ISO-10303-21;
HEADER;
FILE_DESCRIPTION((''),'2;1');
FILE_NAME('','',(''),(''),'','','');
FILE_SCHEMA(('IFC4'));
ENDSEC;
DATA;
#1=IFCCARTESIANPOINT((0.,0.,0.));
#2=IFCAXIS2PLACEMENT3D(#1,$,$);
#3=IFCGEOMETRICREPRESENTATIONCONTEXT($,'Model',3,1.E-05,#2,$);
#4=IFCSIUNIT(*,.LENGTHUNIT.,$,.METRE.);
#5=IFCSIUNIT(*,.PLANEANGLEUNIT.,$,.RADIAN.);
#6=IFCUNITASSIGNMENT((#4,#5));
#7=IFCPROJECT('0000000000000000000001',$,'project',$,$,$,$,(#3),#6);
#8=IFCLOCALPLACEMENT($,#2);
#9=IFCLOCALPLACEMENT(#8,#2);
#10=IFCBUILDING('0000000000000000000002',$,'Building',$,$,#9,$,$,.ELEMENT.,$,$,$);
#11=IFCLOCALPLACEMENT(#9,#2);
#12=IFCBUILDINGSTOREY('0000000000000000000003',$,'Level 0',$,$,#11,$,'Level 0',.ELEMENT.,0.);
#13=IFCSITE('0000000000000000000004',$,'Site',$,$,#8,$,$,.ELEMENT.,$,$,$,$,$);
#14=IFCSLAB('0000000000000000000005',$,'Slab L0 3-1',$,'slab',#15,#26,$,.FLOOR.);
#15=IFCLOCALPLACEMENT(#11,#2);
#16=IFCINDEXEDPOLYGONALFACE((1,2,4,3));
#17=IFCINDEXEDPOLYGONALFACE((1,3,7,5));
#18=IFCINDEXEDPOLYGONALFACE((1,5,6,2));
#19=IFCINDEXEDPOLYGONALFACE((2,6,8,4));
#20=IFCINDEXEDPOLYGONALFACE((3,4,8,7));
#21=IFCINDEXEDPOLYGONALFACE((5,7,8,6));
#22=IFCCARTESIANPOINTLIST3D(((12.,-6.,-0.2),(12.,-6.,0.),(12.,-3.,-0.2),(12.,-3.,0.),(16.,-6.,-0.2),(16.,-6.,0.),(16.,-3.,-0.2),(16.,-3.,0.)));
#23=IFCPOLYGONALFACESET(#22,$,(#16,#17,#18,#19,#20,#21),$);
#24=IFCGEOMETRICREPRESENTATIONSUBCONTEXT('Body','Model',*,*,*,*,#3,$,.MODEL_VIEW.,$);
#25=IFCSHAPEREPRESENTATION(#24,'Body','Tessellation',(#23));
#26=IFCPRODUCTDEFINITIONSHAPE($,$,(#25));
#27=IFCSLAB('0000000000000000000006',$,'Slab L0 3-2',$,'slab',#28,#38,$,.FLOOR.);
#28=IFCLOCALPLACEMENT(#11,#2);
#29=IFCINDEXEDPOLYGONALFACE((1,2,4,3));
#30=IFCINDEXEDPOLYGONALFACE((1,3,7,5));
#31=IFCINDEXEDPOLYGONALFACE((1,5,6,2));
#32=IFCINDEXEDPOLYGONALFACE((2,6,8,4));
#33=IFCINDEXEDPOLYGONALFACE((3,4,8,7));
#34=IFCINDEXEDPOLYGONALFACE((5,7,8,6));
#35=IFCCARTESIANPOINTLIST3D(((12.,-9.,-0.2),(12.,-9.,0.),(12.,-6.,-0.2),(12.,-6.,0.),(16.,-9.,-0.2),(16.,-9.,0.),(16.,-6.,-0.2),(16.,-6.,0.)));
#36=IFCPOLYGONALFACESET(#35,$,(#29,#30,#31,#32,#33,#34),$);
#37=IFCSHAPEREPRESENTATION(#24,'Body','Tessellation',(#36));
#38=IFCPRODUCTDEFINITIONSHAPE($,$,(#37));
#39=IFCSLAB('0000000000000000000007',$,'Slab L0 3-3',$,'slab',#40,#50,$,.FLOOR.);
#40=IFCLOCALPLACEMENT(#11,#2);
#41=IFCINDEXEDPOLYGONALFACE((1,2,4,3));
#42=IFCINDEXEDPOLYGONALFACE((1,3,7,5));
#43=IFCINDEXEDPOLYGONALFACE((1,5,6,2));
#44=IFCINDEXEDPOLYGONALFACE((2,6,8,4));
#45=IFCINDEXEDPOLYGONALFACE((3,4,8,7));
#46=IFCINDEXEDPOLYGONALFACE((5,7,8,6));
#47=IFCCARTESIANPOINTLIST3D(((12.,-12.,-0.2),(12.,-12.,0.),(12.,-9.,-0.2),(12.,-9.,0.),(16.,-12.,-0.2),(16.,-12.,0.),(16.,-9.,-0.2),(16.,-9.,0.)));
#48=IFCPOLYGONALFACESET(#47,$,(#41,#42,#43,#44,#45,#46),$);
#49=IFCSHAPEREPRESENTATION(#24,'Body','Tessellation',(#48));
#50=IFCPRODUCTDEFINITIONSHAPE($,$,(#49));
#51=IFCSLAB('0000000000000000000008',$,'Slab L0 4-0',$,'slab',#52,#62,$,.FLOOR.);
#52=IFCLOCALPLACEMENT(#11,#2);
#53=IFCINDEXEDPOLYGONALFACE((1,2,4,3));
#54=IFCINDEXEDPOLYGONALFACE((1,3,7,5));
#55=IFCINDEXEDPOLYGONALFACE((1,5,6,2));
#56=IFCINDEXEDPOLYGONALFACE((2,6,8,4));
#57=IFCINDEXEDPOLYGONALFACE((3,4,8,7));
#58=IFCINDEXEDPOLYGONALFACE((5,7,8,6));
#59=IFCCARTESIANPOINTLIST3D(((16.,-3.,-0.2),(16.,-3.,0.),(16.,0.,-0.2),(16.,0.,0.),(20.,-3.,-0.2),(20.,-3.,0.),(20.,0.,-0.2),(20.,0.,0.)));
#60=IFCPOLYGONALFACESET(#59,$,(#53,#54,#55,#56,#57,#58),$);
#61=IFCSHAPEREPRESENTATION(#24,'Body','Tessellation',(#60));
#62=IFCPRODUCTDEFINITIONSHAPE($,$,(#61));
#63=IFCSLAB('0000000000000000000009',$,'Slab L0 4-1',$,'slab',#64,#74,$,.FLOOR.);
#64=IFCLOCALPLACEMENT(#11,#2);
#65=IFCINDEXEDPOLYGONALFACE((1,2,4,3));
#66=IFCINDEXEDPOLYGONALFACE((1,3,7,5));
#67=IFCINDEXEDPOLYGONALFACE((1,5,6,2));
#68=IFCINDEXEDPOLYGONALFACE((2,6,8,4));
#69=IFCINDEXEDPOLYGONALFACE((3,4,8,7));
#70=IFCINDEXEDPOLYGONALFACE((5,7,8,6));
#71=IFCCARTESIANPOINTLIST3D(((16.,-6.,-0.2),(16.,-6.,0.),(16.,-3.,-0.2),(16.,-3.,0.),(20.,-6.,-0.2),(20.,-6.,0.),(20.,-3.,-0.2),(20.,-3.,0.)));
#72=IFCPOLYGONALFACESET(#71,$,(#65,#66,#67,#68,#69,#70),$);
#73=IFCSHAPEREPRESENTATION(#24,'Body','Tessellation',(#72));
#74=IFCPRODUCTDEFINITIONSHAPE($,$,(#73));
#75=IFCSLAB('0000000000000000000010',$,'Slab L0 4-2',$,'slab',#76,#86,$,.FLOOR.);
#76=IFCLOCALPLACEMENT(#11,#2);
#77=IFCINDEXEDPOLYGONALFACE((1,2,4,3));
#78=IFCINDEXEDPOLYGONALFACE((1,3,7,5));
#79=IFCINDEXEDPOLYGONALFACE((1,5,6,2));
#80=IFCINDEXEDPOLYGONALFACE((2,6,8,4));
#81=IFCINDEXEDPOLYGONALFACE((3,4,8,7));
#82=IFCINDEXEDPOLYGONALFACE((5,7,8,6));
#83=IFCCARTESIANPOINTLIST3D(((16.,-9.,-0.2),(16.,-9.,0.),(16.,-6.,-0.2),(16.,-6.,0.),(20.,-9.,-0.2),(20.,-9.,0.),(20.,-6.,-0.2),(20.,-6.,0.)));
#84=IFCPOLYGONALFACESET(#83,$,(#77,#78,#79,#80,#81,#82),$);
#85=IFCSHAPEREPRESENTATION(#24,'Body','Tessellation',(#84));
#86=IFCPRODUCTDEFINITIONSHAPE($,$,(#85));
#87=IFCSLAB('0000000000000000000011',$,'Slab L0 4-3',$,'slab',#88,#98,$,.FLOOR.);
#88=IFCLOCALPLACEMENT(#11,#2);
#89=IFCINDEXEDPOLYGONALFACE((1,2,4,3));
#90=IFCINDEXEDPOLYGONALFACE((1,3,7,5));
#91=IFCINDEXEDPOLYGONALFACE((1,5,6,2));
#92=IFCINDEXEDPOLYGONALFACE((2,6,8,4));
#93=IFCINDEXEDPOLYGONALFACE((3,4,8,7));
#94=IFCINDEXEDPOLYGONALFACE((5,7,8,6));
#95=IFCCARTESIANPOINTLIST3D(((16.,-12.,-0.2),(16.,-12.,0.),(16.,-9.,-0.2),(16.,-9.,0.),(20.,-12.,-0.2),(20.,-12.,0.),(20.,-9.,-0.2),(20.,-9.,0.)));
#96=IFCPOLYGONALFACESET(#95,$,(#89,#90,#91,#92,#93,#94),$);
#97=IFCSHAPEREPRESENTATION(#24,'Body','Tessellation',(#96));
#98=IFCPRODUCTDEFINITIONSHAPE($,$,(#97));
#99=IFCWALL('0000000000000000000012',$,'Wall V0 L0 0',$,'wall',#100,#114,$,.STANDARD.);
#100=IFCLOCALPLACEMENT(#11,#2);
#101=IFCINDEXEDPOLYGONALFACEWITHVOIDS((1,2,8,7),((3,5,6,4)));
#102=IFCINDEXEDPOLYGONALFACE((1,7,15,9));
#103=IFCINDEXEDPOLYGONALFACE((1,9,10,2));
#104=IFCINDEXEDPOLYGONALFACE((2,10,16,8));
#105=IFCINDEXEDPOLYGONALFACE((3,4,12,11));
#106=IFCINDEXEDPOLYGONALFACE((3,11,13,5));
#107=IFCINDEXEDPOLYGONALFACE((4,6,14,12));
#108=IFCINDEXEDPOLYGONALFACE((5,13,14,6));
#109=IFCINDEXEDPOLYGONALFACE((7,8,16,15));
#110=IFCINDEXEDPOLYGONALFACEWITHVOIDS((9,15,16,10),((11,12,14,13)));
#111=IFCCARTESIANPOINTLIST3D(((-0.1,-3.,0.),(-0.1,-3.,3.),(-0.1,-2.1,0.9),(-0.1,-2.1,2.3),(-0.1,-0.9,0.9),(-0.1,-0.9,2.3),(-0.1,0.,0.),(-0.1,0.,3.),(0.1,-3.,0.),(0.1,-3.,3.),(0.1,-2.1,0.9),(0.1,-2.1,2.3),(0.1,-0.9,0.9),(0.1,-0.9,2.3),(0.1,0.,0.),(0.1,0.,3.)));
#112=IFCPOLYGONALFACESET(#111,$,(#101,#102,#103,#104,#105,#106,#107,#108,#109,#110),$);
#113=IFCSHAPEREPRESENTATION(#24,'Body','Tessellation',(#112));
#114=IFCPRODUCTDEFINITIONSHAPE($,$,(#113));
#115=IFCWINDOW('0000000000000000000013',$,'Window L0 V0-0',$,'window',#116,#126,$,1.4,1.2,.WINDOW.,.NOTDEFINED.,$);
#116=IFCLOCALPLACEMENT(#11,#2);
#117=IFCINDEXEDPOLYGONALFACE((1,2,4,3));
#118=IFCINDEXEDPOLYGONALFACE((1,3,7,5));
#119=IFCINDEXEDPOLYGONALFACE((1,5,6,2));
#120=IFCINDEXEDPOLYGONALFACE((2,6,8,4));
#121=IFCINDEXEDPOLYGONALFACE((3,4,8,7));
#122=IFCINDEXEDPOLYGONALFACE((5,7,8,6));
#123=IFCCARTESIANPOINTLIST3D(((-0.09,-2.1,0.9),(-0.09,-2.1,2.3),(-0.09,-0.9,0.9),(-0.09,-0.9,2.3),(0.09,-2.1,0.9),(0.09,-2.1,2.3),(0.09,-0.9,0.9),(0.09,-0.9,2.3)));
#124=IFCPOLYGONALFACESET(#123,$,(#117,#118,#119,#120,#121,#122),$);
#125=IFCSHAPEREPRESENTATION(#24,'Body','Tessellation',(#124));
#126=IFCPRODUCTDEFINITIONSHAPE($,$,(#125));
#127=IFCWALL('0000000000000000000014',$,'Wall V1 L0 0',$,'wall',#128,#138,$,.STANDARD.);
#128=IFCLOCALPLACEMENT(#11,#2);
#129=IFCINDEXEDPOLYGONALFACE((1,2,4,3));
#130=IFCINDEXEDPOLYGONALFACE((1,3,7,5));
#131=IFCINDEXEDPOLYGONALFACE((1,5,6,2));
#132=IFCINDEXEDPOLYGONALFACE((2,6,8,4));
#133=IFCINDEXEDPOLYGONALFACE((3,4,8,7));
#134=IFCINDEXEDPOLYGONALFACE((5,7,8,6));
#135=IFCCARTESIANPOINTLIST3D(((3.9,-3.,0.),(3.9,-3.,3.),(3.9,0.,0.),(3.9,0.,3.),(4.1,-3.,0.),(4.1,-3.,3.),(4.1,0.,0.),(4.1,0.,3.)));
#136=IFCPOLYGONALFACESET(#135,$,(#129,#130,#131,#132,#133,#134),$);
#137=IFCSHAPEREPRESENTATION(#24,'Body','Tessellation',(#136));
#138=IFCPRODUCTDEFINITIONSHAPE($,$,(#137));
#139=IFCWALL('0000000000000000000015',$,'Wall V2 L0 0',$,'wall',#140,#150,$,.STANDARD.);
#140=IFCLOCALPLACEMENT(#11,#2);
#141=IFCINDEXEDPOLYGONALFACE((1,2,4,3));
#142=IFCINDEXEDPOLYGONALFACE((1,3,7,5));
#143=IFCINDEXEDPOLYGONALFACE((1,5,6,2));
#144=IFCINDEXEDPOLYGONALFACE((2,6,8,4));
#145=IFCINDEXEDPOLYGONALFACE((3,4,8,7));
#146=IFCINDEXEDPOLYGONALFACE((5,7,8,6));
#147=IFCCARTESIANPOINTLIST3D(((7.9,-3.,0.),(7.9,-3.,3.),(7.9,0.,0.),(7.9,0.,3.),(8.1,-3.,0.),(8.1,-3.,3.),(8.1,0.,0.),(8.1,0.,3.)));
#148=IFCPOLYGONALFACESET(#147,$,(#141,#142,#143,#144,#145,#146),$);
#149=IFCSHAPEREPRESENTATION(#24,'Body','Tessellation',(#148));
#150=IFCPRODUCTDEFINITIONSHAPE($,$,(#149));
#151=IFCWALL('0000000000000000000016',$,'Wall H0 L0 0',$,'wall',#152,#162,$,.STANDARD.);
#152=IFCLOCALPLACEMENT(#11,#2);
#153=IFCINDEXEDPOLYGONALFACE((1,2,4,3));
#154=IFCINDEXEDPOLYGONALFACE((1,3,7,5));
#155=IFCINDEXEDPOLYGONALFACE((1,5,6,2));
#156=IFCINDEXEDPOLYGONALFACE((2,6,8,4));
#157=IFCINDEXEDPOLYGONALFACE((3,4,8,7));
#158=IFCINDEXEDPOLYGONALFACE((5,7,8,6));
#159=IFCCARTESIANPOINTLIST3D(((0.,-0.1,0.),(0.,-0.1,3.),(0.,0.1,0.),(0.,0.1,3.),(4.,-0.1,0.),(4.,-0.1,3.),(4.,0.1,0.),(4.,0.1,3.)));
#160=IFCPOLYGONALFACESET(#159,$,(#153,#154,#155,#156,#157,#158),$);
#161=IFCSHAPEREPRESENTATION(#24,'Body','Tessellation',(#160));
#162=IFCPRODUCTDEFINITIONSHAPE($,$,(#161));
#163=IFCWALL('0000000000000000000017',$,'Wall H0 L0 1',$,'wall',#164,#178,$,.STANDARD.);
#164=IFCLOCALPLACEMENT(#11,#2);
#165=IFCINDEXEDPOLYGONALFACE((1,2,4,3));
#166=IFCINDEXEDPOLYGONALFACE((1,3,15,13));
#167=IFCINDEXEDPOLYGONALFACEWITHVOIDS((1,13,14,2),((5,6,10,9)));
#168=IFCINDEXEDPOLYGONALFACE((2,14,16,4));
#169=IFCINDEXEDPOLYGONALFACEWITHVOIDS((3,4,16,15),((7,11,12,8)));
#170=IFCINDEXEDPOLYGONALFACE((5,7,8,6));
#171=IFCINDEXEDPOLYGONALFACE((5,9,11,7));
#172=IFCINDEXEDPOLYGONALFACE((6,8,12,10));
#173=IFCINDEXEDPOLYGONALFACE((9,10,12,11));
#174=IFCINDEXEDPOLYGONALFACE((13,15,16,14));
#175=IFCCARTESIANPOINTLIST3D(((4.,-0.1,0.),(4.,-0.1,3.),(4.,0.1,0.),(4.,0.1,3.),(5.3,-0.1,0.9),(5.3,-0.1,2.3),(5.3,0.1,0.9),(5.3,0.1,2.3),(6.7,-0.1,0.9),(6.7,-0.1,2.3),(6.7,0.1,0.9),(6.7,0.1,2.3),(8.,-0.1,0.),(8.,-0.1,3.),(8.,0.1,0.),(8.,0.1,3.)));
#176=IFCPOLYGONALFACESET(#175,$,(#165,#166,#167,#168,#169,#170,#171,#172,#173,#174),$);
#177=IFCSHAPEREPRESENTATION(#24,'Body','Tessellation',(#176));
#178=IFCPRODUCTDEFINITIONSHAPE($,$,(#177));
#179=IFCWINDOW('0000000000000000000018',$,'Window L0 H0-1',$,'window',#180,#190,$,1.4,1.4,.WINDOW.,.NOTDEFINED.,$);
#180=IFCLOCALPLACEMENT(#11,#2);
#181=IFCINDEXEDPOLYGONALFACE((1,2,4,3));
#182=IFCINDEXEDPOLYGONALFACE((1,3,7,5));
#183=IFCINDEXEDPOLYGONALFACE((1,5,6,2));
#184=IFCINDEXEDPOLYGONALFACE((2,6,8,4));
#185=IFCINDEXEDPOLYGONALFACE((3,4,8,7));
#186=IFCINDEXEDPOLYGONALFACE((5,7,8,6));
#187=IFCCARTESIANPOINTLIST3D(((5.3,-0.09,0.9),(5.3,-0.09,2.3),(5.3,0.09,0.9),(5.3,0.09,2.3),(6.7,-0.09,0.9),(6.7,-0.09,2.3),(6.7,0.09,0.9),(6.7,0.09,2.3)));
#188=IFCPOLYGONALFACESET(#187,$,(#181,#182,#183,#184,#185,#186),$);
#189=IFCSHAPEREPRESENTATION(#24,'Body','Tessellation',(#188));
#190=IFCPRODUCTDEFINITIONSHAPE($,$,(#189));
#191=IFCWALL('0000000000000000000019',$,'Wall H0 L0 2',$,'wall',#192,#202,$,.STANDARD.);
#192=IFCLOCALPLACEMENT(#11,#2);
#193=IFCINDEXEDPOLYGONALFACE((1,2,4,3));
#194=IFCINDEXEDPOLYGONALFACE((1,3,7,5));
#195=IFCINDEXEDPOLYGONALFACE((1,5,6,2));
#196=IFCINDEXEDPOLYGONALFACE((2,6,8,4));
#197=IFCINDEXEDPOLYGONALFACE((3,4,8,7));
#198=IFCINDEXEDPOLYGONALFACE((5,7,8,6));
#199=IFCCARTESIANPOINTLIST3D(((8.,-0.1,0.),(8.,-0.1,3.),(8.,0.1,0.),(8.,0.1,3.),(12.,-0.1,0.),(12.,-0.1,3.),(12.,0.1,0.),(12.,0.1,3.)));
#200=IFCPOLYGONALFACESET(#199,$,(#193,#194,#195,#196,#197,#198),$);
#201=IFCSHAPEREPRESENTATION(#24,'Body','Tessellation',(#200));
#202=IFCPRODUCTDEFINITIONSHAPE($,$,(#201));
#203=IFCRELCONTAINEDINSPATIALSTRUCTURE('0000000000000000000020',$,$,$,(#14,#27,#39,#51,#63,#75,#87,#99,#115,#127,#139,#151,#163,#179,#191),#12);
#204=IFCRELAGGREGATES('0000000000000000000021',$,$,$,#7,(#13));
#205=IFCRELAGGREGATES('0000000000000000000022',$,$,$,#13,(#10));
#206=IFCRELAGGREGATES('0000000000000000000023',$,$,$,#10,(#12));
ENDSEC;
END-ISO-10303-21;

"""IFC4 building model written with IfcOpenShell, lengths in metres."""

from ifc_helpers import new_model, si_unit, frame, frame_2d, origin, origin_with_axes, origin_2d, place, context, subcontext, project, spatial, polyline, rectangle, outline, extrude, element, fill, save


model = new_model("IFC4")

# Units and contexts
model_context = context("Model", 3, precision=1e-05, world=origin())
body_context = subcontext(model_context, "Body", "Model", "MODEL_VIEW")
ifc_project = project(units=[si_unit("LENGTHUNIT", "METRE"), si_unit("PLANEANGLEUNIT", "RADIAN")], contexts=[model_context])

# Site, building, storey
site_placement = place(None, origin())
site = spatial("IfcSite", under=ifc_project, at=site_placement, Name="Site", CompositionType="ELEMENT")
building_placement = place(site_placement, origin())
building = spatial("IfcBuilding", under=site, at=building_placement, Name="Building", CompositionType="ELEMENT")
storey_placement = place(building_placement, origin())
storey = spatial("IfcBuildingStorey", under=building, at=storey_placement, Name="Level 0", LongName="Level 0", CompositionType="ELEMENT", Elevation=0.0)

# Slabs
slab_1_placement = place(storey_placement, frame((0.0, 0.0, -0.2)))
element("IfcSlab", 1, at=slab_1_placement, inside=storey, Name="Slab L0 3-1", ObjectType="slab", PredefinedType="FLOOR", context=body_context, shape_type="SweptSolid", body=[
    extrude(outline(polyline([(12.0, -6.0), (16.0, -6.0), (16.0, -3.0), (12.0, -3.0), (12.0, -6.0)])), origin(), (0.0, 0.0, 1.0), 0.2),
])
slab_2_placement = place(storey_placement, frame((0.0, 0.0, -0.2)))
element("IfcSlab", 2, at=slab_2_placement, inside=storey, Name="Slab L0 3-2", ObjectType="slab", PredefinedType="FLOOR", context=body_context, shape_type="SweptSolid", body=[
    extrude(outline(polyline([(12.0, -9.0), (16.0, -9.0), (16.0, -6.0), (12.0, -6.0), (12.0, -9.0)])), origin(), (0.0, 0.0, 1.0), 0.2),
])
slab_3_placement = place(storey_placement, frame((0.0, 0.0, -0.2)))
element("IfcSlab", 3, at=slab_3_placement, inside=storey, Name="Slab L0 3-3", ObjectType="slab", PredefinedType="FLOOR", context=body_context, shape_type="SweptSolid", body=[
    extrude(outline(polyline([(12.0, -12.0), (16.0, -12.0), (16.0, -9.0), (12.0, -9.0), (12.0, -12.0)])), origin(), (0.0, 0.0, 1.0), 0.2),
])
slab_4_placement = place(storey_placement, frame((0.0, 0.0, -0.2)))
element("IfcSlab", 4, at=slab_4_placement, inside=storey, Name="Slab L0 4-0", ObjectType="slab", PredefinedType="FLOOR", context=body_context, shape_type="SweptSolid", body=[
    extrude(outline(polyline([(16.0, -3.0), (20.0, -3.0), (20.0, 0.0), (16.0, 0.0), (16.0, -3.0)])), origin(), (0.0, 0.0, 1.0), 0.2),
])
slab_5_placement = place(storey_placement, frame((0.0, 0.0, -0.2)))
element("IfcSlab", 5, at=slab_5_placement, inside=storey, Name="Slab L0 4-1", ObjectType="slab", PredefinedType="FLOOR", context=body_context, shape_type="SweptSolid", body=[
    extrude(outline(polyline([(16.0, -6.0), (20.0, -6.0), (20.0, -3.0), (16.0, -3.0), (16.0, -6.0)])), origin(), (0.0, 0.0, 1.0), 0.2),
])
slab_6_placement = place(storey_placement, frame((0.0, 0.0, -0.2)))
element("IfcSlab", 6, at=slab_6_placement, inside=storey, Name="Slab L0 4-2", ObjectType="slab", PredefinedType="FLOOR", context=body_context, shape_type="SweptSolid", body=[
    extrude(outline(polyline([(16.0, -9.0), (20.0, -9.0), (20.0, -6.0), (16.0, -6.0), (16.0, -9.0)])), origin(), (0.0, 0.0, 1.0), 0.2),
])
slab_7_placement = place(storey_placement, frame((0.0, 0.0, -0.2)))
element("IfcSlab", 7, at=slab_7_placement, inside=storey, Name="Slab L0 4-3", ObjectType="slab", PredefinedType="FLOOR", context=body_context, shape_type="SweptSolid", body=[
    extrude(outline(polyline([(16.0, -12.0), (20.0, -12.0), (20.0, -9.0), (16.0, -9.0), (16.0, -12.0)])), origin(), (0.0, 0.0, 1.0), 0.2),
])

# Wall, opening, window
wall_1_placement = place(storey_placement, frame((0.0, 0.0, 0.0), z_axis=(0.0, 0.0, 1.0), x_axis=(0.0, -1.0, 0.0)))
wall_1 = element("IfcWall", 8, at=wall_1_placement, inside=storey, Name="Wall V0 L0 0", ObjectType="wall", PredefinedType="STANDARD", context=body_context, shape_type="SweptSolid", body=[
    extrude(rectangle(XDim=3.0, YDim=0.2, at=frame_2d((1.5, 0.0))), origin(), (0.0, 0.0, 1.0), 3.0),
])
opening_1_placement = place(storey_placement, frame((0.0, -1.5, 0.9), z_axis=(0.0, 0.0, 1.0), x_axis=(0.0, -1.0, 0.0)))
opening_1 = element("IfcOpeningElement", 9, at=opening_1_placement, cuts=wall_1, ObjectType="Opening", PredefinedType="OPENING", context=body_context, shape_type="SweptSolid", body=[
    extrude(rectangle(XDim=1.2, YDim=0.22, at=origin_2d()), origin(), (0.0, 0.0, 1.0), 1.4),
])
window_1_placement = place(storey_placement, frame((0.0, -1.5, 0.9), z_axis=(0.0, 0.0, 1.0), x_axis=(0.0, -1.0, 0.0)))
window_1 = element("IfcWindow", 10, at=window_1_placement, inside=storey, Name="Window L0 V0-0", ObjectType="window", OverallHeight=1.4, OverallWidth=1.2, PartitioningType="NOTDEFINED", PredefinedType="WINDOW", context=body_context, shape_type="SweptSolid", body=[
    extrude(rectangle(XDim=1.2, YDim=0.18, at=origin_2d()), origin(), (0.0, 0.0, 1.0), 1.4),
])
fill(opening_1, window_1)

# Walls
for number, where, z_axis, x_axis, name in (
    (11, (4.0, 0.0, 0.0), (0.0, 0.0, 1.0), (0.0, -1.0, 0.0), "Wall V1 L0 0"),
    (12, (8.0, 0.0, 0.0), (0.0, 0.0, 1.0), (0.0, -1.0, 0.0), "Wall V2 L0 0"),
):
    element("IfcWall", number, at=place(storey_placement, frame(where, z_axis=z_axis, x_axis=x_axis)), inside=storey, Name=name, ObjectType="wall", PredefinedType="STANDARD", context=body_context, shape_type="SweptSolid", body=[
        extrude(rectangle(XDim=3.0, YDim=0.2, at=frame_2d((1.5, 0.0))), origin(), (0.0, 0.0, 1.0), 3.0),
    ])
wall_2_placement = place(storey_placement, origin_with_axes())
element("IfcWall", 13, at=wall_2_placement, inside=storey, Name="Wall H0 L0 0", ObjectType="wall", PredefinedType="STANDARD", context=body_context, shape_type="SweptSolid", body=[
    extrude(rectangle(XDim=4.0, YDim=0.2, at=frame_2d((2.0, 0.0))), origin(), (0.0, 0.0, 1.0), 3.0),
])

# Wall, opening, window
wall_3_placement = place(storey_placement, frame((4.0, 0.0, 0.0), z_axis=(0.0, 0.0, 1.0), x_axis=(1.0, 0.0, 0.0)))
wall_3 = element("IfcWall", 14, at=wall_3_placement, inside=storey, Name="Wall H0 L0 1", ObjectType="wall", PredefinedType="STANDARD", context=body_context, shape_type="SweptSolid", body=[
    extrude(rectangle(XDim=4.0, YDim=0.2, at=frame_2d((2.0, 0.0))), origin(), (0.0, 0.0, 1.0), 3.0),
])
opening_2_placement = place(storey_placement, frame((6.0, 0.0, 0.9), z_axis=(0.0, 0.0, 1.0), x_axis=(1.0, 0.0, 0.0)))
opening_2 = element("IfcOpeningElement", 15, at=opening_2_placement, cuts=wall_3, ObjectType="Opening", PredefinedType="OPENING", context=body_context, shape_type="SweptSolid", body=[
    extrude(rectangle(XDim=1.4, YDim=0.22, at=origin_2d()), origin(), (0.0, 0.0, 1.0), 1.4),
])
window_2_placement = place(storey_placement, frame((6.0, 0.0, 0.9), z_axis=(0.0, 0.0, 1.0), x_axis=(1.0, 0.0, 0.0)))
window_2 = element("IfcWindow", 16, at=window_2_placement, inside=storey, Name="Window L0 H0-1", ObjectType="window", OverallHeight=1.4, OverallWidth=1.4, PartitioningType="NOTDEFINED", PredefinedType="WINDOW", context=body_context, shape_type="SweptSolid", body=[
    extrude(rectangle(XDim=1.4, YDim=0.18, at=origin_2d()), origin(), (0.0, 0.0, 1.0), 1.4),
])
fill(opening_2, window_2)

# Wall
wall_4_placement = place(storey_placement, frame((8.0, 0.0, 0.0), z_axis=(0.0, 0.0, 1.0), x_axis=(1.0, 0.0, 0.0)))
element("IfcWall", 17, at=wall_4_placement, inside=storey, Name="Wall H0 L0 2", ObjectType="wall", PredefinedType="STANDARD", context=body_context, shape_type="SweptSolid", body=[
    extrude(rectangle(XDim=4.0, YDim=0.2, at=frame_2d((2.0, 0.0))), origin(), (0.0, 0.0, 1.0), 3.0),
])

save(model, "model.ifc")
